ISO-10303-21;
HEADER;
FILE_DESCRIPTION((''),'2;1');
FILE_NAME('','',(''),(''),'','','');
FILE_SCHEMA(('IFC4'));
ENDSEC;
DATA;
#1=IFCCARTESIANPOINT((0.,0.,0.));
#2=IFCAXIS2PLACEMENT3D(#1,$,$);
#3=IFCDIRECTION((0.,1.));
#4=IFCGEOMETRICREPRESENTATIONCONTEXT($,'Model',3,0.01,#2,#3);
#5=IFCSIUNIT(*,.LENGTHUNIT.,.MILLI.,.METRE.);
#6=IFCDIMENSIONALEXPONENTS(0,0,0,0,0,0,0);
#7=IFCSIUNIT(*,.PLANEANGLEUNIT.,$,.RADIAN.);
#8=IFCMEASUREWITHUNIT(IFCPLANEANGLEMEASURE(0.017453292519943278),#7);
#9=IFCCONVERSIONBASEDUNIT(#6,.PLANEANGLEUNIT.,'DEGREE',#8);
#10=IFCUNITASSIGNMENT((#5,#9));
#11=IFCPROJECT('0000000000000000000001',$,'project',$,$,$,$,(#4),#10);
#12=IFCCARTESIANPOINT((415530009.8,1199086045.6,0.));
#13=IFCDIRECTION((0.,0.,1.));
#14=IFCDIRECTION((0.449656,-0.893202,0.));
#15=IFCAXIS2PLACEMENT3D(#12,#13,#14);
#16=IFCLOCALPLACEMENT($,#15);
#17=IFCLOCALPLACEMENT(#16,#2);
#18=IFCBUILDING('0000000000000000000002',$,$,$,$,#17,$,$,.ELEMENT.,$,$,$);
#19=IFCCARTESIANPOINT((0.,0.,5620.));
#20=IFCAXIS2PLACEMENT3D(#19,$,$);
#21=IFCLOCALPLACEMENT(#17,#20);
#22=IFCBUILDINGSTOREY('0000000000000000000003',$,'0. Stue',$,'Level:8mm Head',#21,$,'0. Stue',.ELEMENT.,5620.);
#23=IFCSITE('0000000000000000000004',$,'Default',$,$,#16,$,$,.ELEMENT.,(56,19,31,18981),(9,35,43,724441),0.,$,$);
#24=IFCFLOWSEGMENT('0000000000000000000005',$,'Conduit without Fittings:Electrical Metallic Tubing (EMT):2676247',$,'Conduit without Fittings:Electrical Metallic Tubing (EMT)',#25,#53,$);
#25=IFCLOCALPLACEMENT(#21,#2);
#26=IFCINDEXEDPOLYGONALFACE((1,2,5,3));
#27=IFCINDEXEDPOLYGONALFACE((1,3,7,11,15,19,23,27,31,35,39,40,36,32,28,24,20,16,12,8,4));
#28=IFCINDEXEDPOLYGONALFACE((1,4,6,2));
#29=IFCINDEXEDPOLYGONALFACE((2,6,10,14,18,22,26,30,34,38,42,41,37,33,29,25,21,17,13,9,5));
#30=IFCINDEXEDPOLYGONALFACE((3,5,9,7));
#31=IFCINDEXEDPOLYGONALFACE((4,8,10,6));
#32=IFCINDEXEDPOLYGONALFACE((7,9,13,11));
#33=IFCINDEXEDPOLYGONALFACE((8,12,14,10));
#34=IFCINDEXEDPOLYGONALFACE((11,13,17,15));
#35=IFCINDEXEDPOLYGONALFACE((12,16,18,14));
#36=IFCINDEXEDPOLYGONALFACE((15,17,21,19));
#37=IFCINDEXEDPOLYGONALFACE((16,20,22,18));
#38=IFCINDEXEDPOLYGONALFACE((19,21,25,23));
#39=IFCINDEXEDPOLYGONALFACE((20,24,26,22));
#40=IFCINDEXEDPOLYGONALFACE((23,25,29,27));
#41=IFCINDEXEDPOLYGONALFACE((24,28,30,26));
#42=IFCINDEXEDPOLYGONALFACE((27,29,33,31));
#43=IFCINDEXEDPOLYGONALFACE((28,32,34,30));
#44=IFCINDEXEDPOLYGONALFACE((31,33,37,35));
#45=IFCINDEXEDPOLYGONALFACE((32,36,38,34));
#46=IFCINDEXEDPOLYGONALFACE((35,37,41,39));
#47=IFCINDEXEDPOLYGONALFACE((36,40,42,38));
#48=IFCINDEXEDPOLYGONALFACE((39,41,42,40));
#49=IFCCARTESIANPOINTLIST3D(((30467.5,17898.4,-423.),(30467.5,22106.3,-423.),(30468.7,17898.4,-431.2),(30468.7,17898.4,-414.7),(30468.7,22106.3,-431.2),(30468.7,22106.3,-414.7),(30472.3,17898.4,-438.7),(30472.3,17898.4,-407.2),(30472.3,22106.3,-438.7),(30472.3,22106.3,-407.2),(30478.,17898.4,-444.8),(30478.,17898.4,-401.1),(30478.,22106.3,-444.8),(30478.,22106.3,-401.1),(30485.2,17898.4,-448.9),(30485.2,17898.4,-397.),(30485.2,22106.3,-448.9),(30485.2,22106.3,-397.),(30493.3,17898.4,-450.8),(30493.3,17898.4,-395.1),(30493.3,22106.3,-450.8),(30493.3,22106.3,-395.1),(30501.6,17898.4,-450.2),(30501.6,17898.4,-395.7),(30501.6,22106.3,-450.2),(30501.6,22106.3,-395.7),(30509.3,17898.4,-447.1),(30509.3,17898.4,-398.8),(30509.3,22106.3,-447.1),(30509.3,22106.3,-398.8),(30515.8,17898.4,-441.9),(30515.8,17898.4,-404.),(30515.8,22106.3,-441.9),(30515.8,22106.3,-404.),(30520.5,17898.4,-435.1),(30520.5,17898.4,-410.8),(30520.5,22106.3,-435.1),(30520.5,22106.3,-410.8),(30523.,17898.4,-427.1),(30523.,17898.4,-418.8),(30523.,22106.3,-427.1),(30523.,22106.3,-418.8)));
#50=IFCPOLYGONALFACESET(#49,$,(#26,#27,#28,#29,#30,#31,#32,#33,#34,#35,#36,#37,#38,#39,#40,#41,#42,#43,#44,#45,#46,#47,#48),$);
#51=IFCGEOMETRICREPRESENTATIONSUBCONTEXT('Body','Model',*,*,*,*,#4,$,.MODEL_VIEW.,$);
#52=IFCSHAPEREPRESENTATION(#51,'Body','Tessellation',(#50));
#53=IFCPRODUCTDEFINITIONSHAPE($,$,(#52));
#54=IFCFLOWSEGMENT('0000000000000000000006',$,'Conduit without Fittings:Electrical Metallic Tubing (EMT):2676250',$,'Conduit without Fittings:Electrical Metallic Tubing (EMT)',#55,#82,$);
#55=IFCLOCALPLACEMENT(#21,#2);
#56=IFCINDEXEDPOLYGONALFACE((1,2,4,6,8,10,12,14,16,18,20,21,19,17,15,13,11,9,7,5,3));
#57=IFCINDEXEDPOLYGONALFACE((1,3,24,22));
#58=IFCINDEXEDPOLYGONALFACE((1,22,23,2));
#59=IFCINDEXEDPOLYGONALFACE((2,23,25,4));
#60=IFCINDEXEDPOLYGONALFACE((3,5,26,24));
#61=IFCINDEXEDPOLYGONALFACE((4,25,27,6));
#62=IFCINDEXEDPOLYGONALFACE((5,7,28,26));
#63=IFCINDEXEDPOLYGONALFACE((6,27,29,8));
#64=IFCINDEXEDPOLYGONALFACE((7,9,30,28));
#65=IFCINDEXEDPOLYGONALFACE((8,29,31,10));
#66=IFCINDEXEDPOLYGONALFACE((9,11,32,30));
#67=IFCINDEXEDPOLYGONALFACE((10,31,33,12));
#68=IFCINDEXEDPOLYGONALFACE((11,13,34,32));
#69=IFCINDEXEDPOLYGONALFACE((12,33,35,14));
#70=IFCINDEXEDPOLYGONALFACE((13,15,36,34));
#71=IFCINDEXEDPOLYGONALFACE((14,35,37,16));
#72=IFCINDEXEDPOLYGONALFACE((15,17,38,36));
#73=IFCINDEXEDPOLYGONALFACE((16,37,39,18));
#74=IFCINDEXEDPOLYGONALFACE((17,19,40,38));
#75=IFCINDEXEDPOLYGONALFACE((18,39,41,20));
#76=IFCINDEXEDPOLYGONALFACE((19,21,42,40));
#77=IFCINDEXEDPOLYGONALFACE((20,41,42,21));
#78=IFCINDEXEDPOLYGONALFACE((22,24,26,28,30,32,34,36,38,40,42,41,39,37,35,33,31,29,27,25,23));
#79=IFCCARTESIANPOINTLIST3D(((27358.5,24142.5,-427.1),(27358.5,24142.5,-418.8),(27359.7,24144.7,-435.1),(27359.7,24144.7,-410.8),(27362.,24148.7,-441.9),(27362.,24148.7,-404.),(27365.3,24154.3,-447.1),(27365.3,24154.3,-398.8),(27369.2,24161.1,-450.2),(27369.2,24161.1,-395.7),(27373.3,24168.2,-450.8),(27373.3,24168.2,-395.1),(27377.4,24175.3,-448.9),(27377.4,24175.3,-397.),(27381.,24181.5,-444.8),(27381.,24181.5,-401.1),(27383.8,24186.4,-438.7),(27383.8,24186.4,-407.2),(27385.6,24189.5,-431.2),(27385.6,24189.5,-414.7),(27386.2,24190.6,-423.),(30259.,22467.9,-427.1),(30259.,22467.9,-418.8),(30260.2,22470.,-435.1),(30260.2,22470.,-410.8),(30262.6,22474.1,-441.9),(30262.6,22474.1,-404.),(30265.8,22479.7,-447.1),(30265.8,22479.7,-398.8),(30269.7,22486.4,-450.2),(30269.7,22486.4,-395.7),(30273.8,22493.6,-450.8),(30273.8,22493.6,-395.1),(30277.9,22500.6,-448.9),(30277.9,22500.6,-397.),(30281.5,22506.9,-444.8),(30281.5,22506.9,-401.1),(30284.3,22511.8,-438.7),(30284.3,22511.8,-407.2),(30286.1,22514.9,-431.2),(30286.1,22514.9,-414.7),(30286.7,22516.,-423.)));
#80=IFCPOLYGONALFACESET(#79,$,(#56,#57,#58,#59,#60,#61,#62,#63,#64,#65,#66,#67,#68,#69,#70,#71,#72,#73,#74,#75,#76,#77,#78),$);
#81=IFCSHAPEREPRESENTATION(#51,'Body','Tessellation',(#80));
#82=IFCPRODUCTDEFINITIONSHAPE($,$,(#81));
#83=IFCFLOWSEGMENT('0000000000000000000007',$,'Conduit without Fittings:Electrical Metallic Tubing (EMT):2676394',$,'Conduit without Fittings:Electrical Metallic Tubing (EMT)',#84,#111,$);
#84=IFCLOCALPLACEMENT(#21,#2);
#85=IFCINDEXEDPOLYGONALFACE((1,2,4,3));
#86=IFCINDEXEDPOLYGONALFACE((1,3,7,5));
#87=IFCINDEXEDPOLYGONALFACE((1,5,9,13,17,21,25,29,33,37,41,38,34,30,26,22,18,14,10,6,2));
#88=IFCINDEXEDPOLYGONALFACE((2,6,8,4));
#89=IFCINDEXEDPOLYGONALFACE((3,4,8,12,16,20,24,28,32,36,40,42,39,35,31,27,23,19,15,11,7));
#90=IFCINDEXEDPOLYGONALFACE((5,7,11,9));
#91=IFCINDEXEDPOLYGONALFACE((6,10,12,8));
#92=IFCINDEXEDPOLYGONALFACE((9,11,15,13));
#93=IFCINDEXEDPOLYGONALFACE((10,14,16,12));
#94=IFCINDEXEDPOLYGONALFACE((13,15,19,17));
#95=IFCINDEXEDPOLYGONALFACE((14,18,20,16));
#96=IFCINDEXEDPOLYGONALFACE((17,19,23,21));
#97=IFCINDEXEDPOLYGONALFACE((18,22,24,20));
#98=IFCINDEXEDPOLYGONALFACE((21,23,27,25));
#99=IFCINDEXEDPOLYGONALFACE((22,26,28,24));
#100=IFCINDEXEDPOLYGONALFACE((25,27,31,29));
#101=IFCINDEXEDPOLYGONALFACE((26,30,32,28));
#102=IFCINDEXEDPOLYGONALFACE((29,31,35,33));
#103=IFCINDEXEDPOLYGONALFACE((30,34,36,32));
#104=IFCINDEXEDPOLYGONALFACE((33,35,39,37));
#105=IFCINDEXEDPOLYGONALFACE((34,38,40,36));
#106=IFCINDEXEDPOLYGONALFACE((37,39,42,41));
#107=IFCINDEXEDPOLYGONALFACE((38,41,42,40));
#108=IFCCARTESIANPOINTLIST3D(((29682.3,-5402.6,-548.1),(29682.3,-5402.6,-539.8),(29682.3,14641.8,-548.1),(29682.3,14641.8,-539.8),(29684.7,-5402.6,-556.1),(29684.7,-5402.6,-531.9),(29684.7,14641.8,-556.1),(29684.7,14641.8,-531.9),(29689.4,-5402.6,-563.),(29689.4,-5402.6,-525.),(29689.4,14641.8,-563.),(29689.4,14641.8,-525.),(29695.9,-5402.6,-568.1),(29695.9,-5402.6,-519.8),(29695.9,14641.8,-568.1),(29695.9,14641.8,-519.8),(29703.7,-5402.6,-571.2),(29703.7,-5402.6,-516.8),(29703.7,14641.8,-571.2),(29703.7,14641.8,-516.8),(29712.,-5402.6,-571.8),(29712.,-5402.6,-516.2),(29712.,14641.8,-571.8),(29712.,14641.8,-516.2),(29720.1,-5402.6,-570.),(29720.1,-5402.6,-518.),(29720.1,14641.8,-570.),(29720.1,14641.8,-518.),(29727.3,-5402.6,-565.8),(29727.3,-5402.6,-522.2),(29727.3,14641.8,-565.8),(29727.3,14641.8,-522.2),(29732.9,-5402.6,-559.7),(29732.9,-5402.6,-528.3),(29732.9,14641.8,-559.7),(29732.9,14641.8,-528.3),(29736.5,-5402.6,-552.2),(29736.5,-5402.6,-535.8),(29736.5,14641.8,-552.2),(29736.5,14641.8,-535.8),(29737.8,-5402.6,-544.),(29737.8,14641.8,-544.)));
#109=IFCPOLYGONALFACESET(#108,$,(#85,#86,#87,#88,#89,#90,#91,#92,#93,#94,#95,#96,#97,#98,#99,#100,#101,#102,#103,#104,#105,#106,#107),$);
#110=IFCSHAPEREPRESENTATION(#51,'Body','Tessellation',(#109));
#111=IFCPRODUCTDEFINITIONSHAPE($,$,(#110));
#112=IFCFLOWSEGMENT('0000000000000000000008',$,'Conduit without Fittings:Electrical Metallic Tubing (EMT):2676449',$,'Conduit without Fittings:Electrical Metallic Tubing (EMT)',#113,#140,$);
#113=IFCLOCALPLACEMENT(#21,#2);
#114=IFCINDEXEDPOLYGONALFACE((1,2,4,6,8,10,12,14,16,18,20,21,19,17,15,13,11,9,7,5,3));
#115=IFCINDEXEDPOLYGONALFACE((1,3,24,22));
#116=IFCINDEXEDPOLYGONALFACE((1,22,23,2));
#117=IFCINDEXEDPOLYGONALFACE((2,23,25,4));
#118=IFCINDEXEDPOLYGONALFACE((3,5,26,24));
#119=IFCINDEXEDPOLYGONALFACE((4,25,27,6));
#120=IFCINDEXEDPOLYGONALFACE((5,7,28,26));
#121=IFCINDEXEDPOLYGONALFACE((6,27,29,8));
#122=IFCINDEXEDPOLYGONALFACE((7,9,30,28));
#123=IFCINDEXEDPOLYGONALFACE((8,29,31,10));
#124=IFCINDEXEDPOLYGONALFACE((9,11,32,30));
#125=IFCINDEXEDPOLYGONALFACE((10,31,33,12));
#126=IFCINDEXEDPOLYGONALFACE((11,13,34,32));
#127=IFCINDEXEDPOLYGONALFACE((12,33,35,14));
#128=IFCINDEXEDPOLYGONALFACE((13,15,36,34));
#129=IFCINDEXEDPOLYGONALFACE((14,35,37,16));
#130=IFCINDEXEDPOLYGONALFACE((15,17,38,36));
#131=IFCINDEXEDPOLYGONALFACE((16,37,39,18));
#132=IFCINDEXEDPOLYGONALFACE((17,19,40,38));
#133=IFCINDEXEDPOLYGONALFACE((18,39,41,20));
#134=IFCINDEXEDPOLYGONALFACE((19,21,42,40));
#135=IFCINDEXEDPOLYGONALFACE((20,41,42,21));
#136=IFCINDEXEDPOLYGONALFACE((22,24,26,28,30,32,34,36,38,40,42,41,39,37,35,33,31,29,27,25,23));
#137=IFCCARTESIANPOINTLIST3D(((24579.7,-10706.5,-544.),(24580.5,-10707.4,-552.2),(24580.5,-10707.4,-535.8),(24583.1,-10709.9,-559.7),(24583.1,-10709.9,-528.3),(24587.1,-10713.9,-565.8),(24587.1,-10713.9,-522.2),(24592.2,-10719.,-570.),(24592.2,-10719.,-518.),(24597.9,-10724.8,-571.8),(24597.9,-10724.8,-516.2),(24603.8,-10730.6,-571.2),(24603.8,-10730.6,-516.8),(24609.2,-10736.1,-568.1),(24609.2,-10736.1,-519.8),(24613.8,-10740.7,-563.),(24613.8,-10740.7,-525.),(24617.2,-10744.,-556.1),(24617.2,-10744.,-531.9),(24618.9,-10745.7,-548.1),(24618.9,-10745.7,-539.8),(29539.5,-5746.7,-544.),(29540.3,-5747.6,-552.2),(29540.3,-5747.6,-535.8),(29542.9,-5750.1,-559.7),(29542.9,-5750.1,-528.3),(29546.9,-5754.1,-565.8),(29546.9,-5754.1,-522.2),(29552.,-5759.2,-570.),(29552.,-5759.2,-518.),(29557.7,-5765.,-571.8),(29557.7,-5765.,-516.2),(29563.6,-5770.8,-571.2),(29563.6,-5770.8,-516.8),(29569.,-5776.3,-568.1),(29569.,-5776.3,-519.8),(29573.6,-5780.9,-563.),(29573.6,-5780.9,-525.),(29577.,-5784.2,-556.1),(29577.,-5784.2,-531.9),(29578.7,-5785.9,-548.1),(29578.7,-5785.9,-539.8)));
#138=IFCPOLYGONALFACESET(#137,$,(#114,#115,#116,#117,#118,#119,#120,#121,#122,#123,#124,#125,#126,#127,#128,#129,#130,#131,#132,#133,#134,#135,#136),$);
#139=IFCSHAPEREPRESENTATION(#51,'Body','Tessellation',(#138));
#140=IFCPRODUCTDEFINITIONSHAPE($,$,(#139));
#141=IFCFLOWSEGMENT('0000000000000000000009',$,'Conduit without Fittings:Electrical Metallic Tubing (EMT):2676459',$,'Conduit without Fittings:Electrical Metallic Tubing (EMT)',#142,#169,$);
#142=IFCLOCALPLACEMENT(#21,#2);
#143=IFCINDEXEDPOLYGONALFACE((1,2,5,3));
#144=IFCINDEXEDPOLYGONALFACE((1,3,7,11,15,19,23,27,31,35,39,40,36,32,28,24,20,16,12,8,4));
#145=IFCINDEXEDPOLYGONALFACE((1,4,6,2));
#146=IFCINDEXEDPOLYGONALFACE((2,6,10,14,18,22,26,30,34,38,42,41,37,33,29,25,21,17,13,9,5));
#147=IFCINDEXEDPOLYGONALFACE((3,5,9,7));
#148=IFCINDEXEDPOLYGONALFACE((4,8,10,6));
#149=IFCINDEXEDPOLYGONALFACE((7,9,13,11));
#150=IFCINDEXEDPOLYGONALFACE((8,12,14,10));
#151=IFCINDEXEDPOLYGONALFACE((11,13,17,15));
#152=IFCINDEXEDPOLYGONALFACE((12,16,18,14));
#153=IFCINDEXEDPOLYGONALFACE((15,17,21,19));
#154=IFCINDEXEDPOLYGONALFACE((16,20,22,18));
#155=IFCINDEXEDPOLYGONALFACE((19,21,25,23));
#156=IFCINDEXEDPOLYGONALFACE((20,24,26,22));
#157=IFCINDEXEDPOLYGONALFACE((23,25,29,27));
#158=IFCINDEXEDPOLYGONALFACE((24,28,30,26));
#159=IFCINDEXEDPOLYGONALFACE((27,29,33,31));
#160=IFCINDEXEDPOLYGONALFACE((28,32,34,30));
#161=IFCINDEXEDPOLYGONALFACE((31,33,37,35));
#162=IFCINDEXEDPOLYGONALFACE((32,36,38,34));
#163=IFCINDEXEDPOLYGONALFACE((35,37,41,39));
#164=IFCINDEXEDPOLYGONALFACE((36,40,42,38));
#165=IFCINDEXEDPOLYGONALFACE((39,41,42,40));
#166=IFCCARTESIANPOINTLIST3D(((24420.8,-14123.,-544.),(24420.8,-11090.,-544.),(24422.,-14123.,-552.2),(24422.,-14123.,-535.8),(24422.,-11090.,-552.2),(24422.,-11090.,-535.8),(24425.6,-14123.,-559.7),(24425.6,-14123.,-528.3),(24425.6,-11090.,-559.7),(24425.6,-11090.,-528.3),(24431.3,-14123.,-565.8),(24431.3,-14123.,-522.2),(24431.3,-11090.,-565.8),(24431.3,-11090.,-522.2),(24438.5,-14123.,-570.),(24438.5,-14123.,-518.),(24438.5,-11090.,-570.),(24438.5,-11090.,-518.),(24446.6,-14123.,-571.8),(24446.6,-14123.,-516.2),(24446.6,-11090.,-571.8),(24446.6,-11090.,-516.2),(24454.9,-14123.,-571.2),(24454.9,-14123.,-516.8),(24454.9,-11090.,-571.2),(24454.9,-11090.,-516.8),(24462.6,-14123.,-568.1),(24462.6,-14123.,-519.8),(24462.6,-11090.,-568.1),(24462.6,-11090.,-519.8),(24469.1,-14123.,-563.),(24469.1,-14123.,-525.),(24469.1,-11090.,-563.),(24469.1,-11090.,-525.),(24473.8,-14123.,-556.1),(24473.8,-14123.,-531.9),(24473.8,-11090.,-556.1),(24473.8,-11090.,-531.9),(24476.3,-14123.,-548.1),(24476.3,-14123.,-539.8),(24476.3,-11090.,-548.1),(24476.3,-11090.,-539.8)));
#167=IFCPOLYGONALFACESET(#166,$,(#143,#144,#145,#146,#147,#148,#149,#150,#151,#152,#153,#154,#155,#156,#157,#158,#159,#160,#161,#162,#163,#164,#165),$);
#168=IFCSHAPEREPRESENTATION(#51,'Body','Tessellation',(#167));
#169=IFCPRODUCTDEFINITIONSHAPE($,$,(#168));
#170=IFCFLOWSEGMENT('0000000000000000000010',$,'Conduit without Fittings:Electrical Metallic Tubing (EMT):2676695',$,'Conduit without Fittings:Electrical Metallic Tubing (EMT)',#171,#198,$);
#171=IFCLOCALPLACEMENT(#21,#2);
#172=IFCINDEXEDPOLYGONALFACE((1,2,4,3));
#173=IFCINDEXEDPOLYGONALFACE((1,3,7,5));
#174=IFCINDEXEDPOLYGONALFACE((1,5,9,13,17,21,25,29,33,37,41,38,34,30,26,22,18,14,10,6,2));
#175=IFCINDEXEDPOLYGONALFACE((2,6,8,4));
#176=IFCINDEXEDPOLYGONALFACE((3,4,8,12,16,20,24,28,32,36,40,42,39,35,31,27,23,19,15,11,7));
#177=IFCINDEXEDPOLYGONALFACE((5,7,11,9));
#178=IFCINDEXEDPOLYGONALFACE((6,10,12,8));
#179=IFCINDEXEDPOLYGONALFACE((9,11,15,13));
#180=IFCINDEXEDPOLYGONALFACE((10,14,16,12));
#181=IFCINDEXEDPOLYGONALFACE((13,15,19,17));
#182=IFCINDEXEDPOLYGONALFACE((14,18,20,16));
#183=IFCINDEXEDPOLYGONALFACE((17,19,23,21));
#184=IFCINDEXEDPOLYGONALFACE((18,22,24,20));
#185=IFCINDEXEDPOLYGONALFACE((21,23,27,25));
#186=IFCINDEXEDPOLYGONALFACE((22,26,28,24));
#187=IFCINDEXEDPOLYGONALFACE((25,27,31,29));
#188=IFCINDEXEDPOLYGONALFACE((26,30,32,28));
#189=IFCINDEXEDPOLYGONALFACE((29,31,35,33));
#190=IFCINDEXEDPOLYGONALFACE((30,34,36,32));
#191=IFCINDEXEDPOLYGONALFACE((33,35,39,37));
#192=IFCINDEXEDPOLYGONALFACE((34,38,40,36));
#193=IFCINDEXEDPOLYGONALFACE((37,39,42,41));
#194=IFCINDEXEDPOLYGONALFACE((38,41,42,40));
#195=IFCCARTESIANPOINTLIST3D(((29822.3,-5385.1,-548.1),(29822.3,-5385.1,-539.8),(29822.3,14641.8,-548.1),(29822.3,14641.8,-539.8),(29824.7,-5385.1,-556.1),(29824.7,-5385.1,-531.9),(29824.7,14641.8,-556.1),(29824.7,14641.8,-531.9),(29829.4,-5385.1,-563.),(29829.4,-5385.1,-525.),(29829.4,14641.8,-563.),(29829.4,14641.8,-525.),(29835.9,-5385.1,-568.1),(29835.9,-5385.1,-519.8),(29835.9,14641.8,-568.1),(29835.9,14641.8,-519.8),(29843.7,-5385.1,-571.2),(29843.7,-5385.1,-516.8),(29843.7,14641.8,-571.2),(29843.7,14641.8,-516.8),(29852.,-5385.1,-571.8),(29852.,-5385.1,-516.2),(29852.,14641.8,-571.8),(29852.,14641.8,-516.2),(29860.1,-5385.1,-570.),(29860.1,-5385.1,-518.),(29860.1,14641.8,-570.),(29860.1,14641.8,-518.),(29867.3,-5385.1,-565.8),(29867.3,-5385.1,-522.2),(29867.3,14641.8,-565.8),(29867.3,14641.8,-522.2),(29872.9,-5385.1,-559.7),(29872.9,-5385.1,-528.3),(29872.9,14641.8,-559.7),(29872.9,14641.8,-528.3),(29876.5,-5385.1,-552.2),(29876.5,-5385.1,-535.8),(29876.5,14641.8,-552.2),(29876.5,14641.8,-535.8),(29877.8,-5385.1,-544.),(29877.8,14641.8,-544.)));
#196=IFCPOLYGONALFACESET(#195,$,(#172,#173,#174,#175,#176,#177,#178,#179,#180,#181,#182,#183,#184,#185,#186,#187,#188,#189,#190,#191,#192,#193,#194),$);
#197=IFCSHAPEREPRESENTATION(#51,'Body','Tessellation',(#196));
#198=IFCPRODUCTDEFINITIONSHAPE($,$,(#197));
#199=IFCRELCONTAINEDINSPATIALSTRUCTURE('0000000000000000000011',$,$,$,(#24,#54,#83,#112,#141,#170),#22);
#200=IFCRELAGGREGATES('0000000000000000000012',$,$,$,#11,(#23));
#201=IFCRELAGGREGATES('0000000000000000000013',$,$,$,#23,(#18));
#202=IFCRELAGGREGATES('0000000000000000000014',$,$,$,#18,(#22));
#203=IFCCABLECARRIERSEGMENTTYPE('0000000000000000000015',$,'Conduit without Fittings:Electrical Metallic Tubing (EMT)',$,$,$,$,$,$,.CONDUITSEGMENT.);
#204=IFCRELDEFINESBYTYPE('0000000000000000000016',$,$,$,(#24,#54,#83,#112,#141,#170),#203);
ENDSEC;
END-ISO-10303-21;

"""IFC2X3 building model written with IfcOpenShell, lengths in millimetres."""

from ifc_helpers import new_model, entity, si_unit, converted_unit, direction, frame, frame_2d, origin, origin_2d_with_axis, place, context, subcontext, project, spatial, circle, extrude, type_object, element, save


model = new_model("IFC2X3")

# Units and contexts
model_context = context("Model", 3, precision=0.01, world=origin(), true_north=direction((0.0, 1.0)))
body_context = subcontext(model_context, "Body", "Model", "MODEL_VIEW")
ifc_project = project(units=[si_unit("LENGTHUNIT", "METRE", prefix="MILLI"), converted_unit("PLANEANGLEUNIT", "DEGREE", entity("IfcPlaneAngleMeasure", 0.017453292519943278), si_unit("PLANEANGLEUNIT", "RADIAN"), dimensions=[0, 0, 0, 0, 0, 0, 0])], contexts=[model_context])

# Site, building, storey
site_placement = place(None, frame((415530009.8, 1199086045.6, 0.0), z_axis=(0.0, 0.0, 1.0), x_axis=(0.449656, -0.893202, 0.0)))
site = spatial("IfcSite", under=ifc_project, at=site_placement, Name="Default", CompositionType="ELEMENT", RefLatitude=(56, 19, 31, 18981), RefLongitude=(9, 35, 43, 724441), RefElevation=0.0)
building_placement = place(site_placement, origin())
building = spatial("IfcBuilding", under=site, at=building_placement, CompositionType="ELEMENT")
storey_placement = place(building_placement, frame((0.0, 0.0, 5620.0)))
storey = spatial("IfcBuildingStorey", under=building, at=storey_placement, Name="0. Stue", ObjectType="Level:8mm Head", LongName="0. Stue", CompositionType="ELEMENT", Elevation=5620.0)

# Flow segments
cable_carrier_segment_type_1 = type_object("IfcCableCarrierSegmentType", Name="Conduit without Fittings:Electrical Metallic Tubing (EMT)", PredefinedType="CONDUITSEGMENT")
flow_segment_1_placement = place(storey_placement, origin())
element("IfcFlowSegment", 1, at=flow_segment_1_placement, inside=storey, type_object=cable_carrier_segment_type_1, Name="Conduit without Fittings:Electrical Metallic Tubing (EMT):2676247", ObjectType="Conduit without Fittings:Electrical Metallic Tubing (EMT)", context=body_context, shape_type="SweptSolid", body=[
    extrude(circle(Radius=27.9, at=frame_2d((0.0, 0.0), x_axis=(1.0, 0.0))), frame((30495.4, 17898.4, -423.0), z_axis=(0.0, 1.0, 0.0), x_axis=(-1.0, 0.0, 0.0)), (0.0, 0.0, 1.0), 4207.9),
])
flow_segment_2_placement = place(storey_placement, origin())
element("IfcFlowSegment", 2, at=flow_segment_2_placement, inside=storey, type_object=cable_carrier_segment_type_1, Name="Conduit without Fittings:Electrical Metallic Tubing (EMT):2676250", ObjectType="Conduit without Fittings:Electrical Metallic Tubing (EMT)", context=body_context, shape_type="SweptSolid", body=[
    extrude(circle(Radius=27.9, at=frame_2d((0.0, 0.0), x_axis=(1.0, 0.0))), frame((27372.3, 24166.4, -423.0), z_axis=(0.866025, -0.5, 0.0), x_axis=(0.5, 0.866025, 0.0)), (0.0, 0.0, 1.0), 3349.2),
])
flow_segment_3_placement = place(storey_placement, origin())
element("IfcFlowSegment", 3, at=flow_segment_3_placement, inside=storey, type_object=cable_carrier_segment_type_1, Name="Conduit without Fittings:Electrical Metallic Tubing (EMT):2676394", ObjectType="Conduit without Fittings:Electrical Metallic Tubing (EMT)", context=body_context, shape_type="SweptSolid", body=[
    extrude(circle(Radius=27.9, at=origin_2d_with_axis()), frame((29709.9, -5402.6, -544.0), z_axis=(0.0, 1.0, 0.0), x_axis=(1.0, 0.0, 0.0)), (0.0, 0.0, 1.0), 20044.4),
])
flow_segment_4_placement = place(storey_placement, origin())
element("IfcFlowSegment", 4, at=flow_segment_4_placement, inside=storey, type_object=cable_carrier_segment_type_1, Name="Conduit without Fittings:Electrical Metallic Tubing (EMT):2676449", ObjectType="Conduit without Fittings:Electrical Metallic Tubing (EMT)", context=body_context, shape_type="SweptSolid", body=[
    extrude(circle(Radius=27.9, at=origin_2d_with_axis()), frame((24599.4, -10726.2, -544.0), z_axis=(0.707107, 0.707107, 0.0), x_axis=(-0.707107, 0.707107, 0.0)), (0.0, 0.0, 1.0), 7014.2),
])
flow_segment_5_placement = place(storey_placement, origin())
element("IfcFlowSegment", 5, at=flow_segment_5_placement, inside=storey, type_object=cable_carrier_segment_type_1, Name="Conduit without Fittings:Electrical Metallic Tubing (EMT):2676459", ObjectType="Conduit without Fittings:Electrical Metallic Tubing (EMT)", context=body_context, shape_type="SweptSolid", body=[
    extrude(circle(Radius=27.9, at=frame_2d((0.0, 0.0), x_axis=(1.0, 0.0))), frame((24448.7, -14123.0, -544.0), z_axis=(0.0, 1.0, 0.0), x_axis=(-1.0, 0.0, 0.0)), (0.0, 0.0, 1.0), 3032.9),
])
flow_segment_6_placement = place(storey_placement, origin())
element("IfcFlowSegment", 6, at=flow_segment_6_placement, inside=storey, type_object=cable_carrier_segment_type_1, Name="Conduit without Fittings:Electrical Metallic Tubing (EMT):2676695", ObjectType="Conduit without Fittings:Electrical Metallic Tubing (EMT)", context=body_context, shape_type="SweptSolid", body=[
    extrude(circle(Radius=27.9, at=origin_2d_with_axis()), frame((29849.9, -5385.1, -544.0), z_axis=(0.0, 1.0, 0.0), x_axis=(1.0, 0.0, 0.0)), (0.0, 0.0, 1.0), 20026.9),
])

save(model, "model.ifc")
